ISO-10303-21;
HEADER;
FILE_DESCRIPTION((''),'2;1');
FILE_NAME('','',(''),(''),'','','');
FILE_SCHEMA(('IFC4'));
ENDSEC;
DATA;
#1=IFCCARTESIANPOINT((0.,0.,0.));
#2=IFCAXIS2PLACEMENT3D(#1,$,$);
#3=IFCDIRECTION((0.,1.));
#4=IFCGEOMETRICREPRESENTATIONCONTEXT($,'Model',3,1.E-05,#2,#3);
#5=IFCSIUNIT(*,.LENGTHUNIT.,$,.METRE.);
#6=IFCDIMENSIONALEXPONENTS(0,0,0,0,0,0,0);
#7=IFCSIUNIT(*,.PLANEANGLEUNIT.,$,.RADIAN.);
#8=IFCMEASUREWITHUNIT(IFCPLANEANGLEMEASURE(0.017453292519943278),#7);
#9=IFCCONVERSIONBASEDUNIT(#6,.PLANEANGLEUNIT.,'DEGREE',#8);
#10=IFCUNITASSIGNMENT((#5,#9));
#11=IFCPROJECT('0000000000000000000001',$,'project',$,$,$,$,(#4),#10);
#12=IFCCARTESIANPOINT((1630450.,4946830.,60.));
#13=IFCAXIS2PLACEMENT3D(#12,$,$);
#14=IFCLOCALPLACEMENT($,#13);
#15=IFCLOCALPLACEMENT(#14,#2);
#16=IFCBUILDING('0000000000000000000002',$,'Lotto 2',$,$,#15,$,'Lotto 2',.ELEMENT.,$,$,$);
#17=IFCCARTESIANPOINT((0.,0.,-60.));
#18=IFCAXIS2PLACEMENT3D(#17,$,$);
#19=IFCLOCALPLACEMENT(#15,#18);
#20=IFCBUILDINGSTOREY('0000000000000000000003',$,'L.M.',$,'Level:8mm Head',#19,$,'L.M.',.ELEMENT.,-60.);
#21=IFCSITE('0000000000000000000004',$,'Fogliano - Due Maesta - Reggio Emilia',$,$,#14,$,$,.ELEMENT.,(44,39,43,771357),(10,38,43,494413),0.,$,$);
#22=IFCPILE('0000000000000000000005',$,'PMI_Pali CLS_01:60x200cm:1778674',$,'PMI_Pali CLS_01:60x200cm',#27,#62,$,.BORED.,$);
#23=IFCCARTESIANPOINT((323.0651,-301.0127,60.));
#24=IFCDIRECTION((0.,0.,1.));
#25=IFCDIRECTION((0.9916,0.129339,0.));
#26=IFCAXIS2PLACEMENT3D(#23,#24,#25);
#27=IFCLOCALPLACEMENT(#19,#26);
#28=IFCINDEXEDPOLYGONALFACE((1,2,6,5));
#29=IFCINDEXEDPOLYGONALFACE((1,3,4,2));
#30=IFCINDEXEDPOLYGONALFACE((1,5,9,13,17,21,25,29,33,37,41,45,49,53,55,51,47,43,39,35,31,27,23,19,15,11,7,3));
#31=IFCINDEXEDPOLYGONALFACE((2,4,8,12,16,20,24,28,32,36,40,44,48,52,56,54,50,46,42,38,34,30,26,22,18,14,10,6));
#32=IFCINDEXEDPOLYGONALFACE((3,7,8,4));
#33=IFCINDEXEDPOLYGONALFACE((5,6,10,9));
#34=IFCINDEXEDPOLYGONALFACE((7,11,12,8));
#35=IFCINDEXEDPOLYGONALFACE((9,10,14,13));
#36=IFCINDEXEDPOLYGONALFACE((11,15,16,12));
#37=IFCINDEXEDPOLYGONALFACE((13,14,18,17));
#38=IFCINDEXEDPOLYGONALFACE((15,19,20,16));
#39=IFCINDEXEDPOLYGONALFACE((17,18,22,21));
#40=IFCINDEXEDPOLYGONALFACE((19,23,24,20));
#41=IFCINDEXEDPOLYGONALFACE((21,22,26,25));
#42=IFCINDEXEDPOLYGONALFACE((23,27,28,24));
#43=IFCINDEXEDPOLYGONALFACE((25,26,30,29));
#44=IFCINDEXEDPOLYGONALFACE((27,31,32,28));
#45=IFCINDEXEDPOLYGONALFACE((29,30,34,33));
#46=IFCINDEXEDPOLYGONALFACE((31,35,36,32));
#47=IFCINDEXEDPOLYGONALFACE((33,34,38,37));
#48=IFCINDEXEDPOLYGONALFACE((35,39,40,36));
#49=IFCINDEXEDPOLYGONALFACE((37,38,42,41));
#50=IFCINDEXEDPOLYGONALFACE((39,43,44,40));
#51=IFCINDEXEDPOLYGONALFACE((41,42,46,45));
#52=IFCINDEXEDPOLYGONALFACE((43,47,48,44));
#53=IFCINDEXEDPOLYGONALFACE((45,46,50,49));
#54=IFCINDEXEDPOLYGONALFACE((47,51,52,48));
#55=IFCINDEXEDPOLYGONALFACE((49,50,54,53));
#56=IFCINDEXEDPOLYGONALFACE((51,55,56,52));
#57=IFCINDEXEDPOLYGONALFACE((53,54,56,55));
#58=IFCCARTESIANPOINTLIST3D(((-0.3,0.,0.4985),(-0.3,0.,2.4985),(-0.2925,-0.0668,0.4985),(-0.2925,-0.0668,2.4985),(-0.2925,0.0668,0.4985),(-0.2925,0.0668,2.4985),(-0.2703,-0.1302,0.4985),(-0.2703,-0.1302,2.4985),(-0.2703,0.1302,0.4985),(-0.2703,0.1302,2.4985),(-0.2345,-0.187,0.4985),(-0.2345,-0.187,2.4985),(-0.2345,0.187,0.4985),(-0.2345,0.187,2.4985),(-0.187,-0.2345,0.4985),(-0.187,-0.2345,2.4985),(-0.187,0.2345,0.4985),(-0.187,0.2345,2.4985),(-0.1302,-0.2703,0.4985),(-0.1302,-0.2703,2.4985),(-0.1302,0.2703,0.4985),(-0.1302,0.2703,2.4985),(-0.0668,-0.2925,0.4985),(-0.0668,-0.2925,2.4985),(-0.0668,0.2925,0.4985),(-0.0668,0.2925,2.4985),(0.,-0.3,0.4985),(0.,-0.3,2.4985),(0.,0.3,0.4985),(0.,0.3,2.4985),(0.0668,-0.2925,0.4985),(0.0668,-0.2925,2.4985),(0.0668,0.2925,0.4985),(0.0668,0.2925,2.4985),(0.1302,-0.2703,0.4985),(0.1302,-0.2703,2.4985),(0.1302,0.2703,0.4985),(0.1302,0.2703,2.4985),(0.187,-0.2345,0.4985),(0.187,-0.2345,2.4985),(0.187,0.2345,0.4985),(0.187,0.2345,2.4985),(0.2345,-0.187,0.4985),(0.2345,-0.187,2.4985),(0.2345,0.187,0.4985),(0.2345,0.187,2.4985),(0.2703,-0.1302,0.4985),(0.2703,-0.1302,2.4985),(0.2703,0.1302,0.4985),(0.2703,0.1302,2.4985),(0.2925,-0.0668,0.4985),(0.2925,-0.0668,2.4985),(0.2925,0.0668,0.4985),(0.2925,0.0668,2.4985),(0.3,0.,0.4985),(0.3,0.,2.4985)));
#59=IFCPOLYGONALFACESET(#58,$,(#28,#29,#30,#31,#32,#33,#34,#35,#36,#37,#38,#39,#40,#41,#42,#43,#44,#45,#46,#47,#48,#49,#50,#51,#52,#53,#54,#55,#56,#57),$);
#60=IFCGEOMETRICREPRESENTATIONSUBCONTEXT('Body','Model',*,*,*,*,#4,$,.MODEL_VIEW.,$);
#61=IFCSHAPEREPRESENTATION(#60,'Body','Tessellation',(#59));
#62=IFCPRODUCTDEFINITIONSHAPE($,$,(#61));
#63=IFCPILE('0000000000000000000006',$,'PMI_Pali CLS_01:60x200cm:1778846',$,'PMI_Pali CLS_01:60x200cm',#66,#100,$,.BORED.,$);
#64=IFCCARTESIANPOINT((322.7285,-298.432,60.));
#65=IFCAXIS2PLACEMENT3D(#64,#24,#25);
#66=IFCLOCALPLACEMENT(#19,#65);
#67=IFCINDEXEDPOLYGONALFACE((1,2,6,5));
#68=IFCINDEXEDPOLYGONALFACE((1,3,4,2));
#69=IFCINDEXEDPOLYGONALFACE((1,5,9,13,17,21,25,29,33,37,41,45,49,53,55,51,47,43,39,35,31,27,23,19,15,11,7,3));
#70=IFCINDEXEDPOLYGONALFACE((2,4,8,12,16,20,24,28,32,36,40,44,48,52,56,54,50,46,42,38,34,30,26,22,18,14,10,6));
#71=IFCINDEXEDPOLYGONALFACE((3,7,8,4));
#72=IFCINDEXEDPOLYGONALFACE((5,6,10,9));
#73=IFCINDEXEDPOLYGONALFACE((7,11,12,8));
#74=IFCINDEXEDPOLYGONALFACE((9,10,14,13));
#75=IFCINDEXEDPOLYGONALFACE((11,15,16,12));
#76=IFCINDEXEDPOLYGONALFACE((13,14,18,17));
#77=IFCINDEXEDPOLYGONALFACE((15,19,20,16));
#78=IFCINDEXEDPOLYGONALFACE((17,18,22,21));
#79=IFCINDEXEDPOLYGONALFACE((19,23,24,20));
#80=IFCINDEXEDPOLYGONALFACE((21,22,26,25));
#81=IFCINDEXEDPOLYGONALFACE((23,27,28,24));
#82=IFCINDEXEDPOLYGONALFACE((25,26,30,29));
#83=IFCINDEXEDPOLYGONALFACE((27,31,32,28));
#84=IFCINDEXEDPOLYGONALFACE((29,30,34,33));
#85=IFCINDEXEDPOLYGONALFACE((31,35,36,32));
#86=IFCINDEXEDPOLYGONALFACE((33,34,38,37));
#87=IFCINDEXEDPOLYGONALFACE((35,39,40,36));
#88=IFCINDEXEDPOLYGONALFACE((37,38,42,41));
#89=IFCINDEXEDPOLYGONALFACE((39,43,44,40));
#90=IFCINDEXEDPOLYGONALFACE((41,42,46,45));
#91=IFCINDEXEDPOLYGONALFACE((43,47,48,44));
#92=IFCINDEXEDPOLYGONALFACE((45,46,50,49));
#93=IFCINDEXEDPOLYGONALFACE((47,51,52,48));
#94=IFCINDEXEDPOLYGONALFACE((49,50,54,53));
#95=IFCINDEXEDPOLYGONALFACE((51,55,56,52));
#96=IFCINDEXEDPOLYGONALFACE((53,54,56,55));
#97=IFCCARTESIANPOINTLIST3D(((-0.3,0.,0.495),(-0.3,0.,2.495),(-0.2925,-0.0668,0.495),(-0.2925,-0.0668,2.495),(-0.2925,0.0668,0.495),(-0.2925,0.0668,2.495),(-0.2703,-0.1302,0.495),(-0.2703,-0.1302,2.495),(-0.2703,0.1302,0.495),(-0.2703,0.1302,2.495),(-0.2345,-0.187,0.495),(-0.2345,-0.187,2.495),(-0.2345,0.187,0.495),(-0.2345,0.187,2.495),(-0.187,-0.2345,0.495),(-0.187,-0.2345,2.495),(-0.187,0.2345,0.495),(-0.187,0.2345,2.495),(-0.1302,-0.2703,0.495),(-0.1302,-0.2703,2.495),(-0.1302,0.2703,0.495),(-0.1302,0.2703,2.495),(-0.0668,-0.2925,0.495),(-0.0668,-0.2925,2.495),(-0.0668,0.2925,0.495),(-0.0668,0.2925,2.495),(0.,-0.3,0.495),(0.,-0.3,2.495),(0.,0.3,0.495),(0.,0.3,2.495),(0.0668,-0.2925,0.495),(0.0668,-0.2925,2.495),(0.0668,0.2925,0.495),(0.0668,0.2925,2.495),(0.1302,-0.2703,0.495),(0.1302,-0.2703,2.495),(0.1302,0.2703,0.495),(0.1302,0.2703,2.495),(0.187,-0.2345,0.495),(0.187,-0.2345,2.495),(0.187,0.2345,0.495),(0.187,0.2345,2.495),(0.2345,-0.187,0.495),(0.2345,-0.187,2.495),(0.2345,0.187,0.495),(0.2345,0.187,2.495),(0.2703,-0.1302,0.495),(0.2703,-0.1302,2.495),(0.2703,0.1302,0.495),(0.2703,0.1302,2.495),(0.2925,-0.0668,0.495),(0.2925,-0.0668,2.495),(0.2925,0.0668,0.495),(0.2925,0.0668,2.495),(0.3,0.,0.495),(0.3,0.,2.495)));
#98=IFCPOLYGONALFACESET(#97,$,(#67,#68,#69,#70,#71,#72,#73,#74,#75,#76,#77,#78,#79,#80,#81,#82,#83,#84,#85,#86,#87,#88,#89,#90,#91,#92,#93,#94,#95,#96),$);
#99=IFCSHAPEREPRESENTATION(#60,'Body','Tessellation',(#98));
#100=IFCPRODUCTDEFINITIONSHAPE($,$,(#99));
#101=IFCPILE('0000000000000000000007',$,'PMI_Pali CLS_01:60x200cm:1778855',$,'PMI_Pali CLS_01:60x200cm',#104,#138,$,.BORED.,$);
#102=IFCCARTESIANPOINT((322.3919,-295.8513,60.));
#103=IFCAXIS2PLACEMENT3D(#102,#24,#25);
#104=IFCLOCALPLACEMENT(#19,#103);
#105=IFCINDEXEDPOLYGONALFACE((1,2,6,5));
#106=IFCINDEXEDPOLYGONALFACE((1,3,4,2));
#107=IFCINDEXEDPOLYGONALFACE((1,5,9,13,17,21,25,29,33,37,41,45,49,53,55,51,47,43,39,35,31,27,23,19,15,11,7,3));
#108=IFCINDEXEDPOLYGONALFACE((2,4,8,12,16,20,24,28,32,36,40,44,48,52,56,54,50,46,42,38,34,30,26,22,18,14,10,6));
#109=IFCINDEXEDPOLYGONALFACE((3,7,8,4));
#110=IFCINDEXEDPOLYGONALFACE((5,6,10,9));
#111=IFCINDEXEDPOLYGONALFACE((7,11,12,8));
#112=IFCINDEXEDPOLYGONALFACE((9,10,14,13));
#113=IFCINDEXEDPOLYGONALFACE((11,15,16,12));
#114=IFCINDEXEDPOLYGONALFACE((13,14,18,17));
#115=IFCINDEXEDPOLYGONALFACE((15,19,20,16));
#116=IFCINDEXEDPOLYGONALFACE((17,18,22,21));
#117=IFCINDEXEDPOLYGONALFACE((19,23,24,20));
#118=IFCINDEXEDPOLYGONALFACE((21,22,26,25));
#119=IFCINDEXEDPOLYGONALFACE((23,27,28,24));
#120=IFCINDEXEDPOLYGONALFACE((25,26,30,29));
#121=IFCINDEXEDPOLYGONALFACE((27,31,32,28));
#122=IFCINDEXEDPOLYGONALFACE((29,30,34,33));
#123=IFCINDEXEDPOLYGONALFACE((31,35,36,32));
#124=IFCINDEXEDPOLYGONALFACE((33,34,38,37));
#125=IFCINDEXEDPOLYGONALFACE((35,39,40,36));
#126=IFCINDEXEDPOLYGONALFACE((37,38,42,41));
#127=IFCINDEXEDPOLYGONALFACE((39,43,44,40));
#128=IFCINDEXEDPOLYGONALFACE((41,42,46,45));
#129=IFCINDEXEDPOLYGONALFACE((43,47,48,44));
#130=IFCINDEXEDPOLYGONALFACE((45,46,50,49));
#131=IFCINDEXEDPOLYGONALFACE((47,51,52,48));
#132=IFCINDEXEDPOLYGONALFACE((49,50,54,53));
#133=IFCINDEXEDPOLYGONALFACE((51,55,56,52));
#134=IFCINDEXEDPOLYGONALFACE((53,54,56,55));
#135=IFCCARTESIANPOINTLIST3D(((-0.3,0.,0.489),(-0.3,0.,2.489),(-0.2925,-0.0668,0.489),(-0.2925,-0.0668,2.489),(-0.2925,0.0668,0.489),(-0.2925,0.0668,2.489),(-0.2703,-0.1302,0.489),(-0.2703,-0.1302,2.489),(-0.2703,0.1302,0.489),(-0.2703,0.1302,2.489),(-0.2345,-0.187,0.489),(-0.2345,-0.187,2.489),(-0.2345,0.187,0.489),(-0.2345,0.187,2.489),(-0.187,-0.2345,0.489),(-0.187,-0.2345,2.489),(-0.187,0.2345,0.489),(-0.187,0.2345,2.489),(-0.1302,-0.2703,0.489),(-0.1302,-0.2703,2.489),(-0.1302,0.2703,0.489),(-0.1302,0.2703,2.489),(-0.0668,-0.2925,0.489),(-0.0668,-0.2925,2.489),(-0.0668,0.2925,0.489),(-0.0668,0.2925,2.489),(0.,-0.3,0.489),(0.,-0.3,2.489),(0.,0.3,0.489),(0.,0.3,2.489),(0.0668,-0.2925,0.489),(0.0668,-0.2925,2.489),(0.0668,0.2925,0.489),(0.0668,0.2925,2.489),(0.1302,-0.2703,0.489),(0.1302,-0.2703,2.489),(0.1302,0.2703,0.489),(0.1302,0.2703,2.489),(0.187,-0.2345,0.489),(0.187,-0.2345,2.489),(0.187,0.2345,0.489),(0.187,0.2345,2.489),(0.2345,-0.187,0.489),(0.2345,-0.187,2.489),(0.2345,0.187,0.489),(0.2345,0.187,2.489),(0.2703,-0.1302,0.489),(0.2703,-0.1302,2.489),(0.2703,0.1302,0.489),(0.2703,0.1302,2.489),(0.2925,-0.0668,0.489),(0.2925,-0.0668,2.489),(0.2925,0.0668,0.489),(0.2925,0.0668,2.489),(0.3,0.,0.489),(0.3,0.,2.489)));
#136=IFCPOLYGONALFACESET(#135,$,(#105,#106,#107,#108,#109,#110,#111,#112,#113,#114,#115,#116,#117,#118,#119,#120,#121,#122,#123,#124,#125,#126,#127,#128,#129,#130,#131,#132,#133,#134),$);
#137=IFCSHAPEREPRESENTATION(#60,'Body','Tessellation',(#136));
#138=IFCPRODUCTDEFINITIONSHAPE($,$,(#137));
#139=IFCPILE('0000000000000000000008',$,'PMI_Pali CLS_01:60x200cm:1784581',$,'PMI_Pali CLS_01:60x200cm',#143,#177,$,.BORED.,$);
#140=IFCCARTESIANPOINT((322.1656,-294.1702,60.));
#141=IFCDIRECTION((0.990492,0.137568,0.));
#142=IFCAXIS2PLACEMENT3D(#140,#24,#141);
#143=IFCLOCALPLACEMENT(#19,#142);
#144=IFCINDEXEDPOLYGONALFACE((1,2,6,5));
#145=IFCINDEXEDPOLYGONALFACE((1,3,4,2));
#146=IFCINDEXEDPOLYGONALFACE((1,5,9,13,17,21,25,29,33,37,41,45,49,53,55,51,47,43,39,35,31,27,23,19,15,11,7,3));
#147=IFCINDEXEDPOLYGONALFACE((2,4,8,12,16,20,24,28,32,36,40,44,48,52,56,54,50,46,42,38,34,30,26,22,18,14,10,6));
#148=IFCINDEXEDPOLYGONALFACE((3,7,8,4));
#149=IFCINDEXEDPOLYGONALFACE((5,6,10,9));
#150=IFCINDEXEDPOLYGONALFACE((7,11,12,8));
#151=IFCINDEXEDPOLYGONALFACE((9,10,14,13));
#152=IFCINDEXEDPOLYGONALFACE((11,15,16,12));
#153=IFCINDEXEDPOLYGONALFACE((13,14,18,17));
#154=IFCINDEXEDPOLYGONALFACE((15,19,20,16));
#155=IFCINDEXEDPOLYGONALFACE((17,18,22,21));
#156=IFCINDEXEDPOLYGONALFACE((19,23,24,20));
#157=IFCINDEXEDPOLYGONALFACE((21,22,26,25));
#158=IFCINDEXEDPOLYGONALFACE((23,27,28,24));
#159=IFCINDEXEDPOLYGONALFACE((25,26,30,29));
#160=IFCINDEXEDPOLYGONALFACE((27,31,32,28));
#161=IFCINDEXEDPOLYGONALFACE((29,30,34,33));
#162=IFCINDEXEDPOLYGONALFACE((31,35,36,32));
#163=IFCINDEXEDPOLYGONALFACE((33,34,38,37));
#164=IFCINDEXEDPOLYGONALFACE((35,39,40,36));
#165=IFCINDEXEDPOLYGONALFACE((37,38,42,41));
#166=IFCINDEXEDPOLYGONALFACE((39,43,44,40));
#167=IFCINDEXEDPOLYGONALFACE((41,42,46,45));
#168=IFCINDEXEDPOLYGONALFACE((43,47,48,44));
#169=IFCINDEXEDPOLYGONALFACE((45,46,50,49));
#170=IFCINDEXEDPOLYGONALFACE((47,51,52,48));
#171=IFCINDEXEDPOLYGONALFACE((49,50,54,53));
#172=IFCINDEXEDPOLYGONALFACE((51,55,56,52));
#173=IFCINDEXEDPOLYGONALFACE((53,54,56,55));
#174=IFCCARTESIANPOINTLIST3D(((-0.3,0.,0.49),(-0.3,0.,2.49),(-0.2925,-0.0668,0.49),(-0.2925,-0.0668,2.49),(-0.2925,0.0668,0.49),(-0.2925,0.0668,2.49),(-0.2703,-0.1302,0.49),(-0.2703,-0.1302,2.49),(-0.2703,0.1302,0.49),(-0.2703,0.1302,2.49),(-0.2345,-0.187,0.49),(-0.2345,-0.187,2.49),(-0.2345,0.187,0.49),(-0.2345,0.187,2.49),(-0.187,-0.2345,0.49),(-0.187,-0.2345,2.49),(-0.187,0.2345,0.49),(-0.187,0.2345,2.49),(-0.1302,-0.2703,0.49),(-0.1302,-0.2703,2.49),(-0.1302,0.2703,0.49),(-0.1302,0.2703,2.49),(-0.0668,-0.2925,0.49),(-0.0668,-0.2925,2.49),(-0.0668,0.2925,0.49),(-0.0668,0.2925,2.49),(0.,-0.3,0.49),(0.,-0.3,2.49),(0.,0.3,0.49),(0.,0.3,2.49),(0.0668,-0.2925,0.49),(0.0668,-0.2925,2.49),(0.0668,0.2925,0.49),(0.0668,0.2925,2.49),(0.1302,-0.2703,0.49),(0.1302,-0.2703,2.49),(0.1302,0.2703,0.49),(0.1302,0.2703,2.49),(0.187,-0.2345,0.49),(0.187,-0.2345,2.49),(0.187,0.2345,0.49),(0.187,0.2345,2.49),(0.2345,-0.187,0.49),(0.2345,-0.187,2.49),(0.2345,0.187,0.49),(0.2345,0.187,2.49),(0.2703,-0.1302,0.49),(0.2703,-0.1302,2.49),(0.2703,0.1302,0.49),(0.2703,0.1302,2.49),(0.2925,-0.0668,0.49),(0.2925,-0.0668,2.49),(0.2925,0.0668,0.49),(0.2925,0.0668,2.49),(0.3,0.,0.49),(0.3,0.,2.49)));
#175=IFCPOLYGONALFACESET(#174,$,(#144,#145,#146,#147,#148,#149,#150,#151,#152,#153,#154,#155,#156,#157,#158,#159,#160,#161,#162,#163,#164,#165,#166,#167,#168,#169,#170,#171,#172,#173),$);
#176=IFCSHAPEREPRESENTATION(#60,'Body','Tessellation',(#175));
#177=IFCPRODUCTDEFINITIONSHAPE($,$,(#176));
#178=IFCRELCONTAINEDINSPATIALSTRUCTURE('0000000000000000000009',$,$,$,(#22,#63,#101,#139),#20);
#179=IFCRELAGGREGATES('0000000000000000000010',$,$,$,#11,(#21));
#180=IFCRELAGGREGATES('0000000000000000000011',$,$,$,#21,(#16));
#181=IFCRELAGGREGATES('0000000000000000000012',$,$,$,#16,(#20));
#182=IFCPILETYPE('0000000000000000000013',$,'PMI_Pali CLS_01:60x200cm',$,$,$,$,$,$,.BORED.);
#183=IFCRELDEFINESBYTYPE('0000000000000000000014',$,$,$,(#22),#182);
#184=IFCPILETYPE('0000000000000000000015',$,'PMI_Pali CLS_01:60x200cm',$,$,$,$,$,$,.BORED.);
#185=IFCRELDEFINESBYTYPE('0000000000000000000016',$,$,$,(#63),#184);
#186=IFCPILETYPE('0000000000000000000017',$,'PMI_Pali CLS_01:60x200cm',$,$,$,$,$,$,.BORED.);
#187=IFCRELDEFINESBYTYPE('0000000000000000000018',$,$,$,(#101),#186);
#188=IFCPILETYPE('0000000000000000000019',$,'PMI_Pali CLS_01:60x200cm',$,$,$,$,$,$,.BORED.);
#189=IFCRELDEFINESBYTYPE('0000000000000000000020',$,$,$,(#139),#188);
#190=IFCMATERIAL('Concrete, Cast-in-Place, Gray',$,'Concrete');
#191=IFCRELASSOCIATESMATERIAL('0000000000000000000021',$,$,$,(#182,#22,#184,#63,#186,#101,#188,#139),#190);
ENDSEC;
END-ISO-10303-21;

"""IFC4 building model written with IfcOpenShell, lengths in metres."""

from ifc_helpers import new_model, entity, si_unit, converted_unit, direction, frame, origin, place, context, subcontext, project, spatial, arc, indexed_curve, outline, extrude, source, transform, mapped, material, type_object, type_shapes, element, save


model = new_model("IFC4")

# Units and contexts
model_context = context("Model", 3, precision=1e-05, world=origin(), true_north=direction((0.0, 1.0)))
body_context = subcontext(model_context, "Body", "Model", "MODEL_VIEW")
ifc_project = project(units=[si_unit("LENGTHUNIT", "METRE"), converted_unit("PLANEANGLEUNIT", "DEGREE", entity("IfcPlaneAngleMeasure", 0.017453292519943278), si_unit("PLANEANGLEUNIT", "RADIAN"), dimensions=[0, 0, 0, 0, 0, 0, 0])], contexts=[model_context])

# Site, building, storey
site_placement = place(None, frame((1630450.0, 4946830.0, 60.0)))
site = spatial("IfcSite", under=ifc_project, at=site_placement, Name="Fogliano - Due Maesta - Reggio Emilia", CompositionType="ELEMENT", RefLatitude=(44, 39, 43, 771357), RefLongitude=(10, 38, 43, 494413), RefElevation=0.0)
building_placement = place(site_placement, origin())
building = spatial("IfcBuilding", under=site, at=building_placement, Name="Lotto 2", LongName="Lotto 2", CompositionType="ELEMENT")
storey_placement = place(building_placement, frame((0.0, 0.0, -60.0)))
storey = spatial("IfcBuildingStorey", under=building, at=storey_placement, Name="L.M.", ObjectType="Level:8mm Head", LongName="L.M.", CompositionType="ELEMENT", Elevation=-60.0)

# Piles
ifc_material_1 = material(Name="Concrete, Cast-in-Place, Gray", Category="Concrete")
pile_type_1 = type_object("IfcPileType", Name="PMI_Pali CLS_01:60x200cm", PredefinedType="BORED", material=ifc_material_1)
shared_shape_1 = source(origin(), body_context, "Body", "SweptSolid", [
    extrude(outline(indexed_curve([(-0.3, 0.0), (0.0, -0.3), (0.3, 0.0), (0.0, 0.3)], segments=[arc(1, 2, 3), arc(3, 4, 1)], self_intersect=False)), frame((0.0, 0.0, 0.4985)), (0.0, 0.0, 1.0), 2.0),
])
type_shapes(pile_type_1, [shared_shape_1])
pile_1_placement = place(storey_placement, frame((323.0651, -301.0127, 60.0), z_axis=(0.0, 0.0, 1.0), x_axis=(0.9916, 0.129339, 0.0)))
element("IfcPile", 1, at=pile_1_placement, inside=storey, type_object=pile_type_1, material=ifc_material_1, Name="PMI_Pali CLS_01:60x200cm:1778674", ObjectType="PMI_Pali CLS_01:60x200cm", PredefinedType="BORED", context=body_context, shape_type="MappedRepresentation", body=[
    mapped(shared_shape_1, transform((0.0, 0.0, 0.0), scale=1.0)),
])
pile_type_2 = type_object("IfcPileType", Name="PMI_Pali CLS_01:60x200cm", PredefinedType="BORED", material=ifc_material_1)
shared_shape_2 = source(origin(), body_context, "Body", "SweptSolid", [
    extrude(outline(indexed_curve([(-0.3, 0.0), (0.0, -0.3), (0.3, 0.0), (0.0, 0.3)], segments=[arc(1, 2, 3), arc(3, 4, 1)], self_intersect=False)), frame((0.0, 0.0, 0.495)), (0.0, 0.0, 1.0), 2.0),
])
type_shapes(pile_type_2, [shared_shape_2])
pile_2_placement = place(storey_placement, frame((322.7285, -298.432, 60.0), z_axis=(0.0, 0.0, 1.0), x_axis=(0.9916, 0.129339, 0.0)))
element("IfcPile", 2, at=pile_2_placement, inside=storey, type_object=pile_type_2, material=ifc_material_1, Name="PMI_Pali CLS_01:60x200cm:1778846", ObjectType="PMI_Pali CLS_01:60x200cm", PredefinedType="BORED", context=body_context, shape_type="MappedRepresentation", body=[
    mapped(shared_shape_2, transform((0.0, 0.0, 0.0), scale=1.0)),
])
pile_type_3 = type_object("IfcPileType", Name="PMI_Pali CLS_01:60x200cm", PredefinedType="BORED", material=ifc_material_1)
shared_shape_3 = source(origin(), body_context, "Body", "SweptSolid", [
    extrude(outline(indexed_curve([(-0.3, 0.0), (0.0, -0.3), (0.3, 0.0), (0.0, 0.3)], segments=[arc(1, 2, 3), arc(3, 4, 1)], self_intersect=False)), frame((0.0, 0.0, 0.489)), (0.0, 0.0, 1.0), 2.0),
])
type_shapes(pile_type_3, [shared_shape_3])
pile_3_placement = place(storey_placement, frame((322.3919, -295.8513, 60.0), z_axis=(0.0, 0.0, 1.0), x_axis=(0.9916, 0.129339, 0.0)))
element("IfcPile", 3, at=pile_3_placement, inside=storey, type_object=pile_type_3, material=ifc_material_1, Name="PMI_Pali CLS_01:60x200cm:1778855", ObjectType="PMI_Pali CLS_01:60x200cm", PredefinedType="BORED", context=body_context, shape_type="MappedRepresentation", body=[
    mapped(shared_shape_3, transform((0.0, 0.0, 0.0), scale=1.0)),
])
pile_type_4 = type_object("IfcPileType", Name="PMI_Pali CLS_01:60x200cm", PredefinedType="BORED", material=ifc_material_1)
shared_shape_4 = source(origin(), body_context, "Body", "SweptSolid", [
    extrude(outline(indexed_curve([(-0.3, 0.0), (0.0, -0.3), (0.3, 0.0), (0.0, 0.3)], segments=[arc(1, 2, 3), arc(3, 4, 1)], self_intersect=False)), frame((0.0, 0.0, 0.49)), (0.0, 0.0, 1.0), 2.0),
])
type_shapes(pile_type_4, [shared_shape_4])
pile_4_placement = place(storey_placement, frame((322.1656, -294.1702, 60.0), z_axis=(0.0, 0.0, 1.0), x_axis=(0.990492, 0.137568, 0.0)))
element("IfcPile", 4, at=pile_4_placement, inside=storey, type_object=pile_type_4, material=ifc_material_1, Name="PMI_Pali CLS_01:60x200cm:1784581", ObjectType="PMI_Pali CLS_01:60x200cm", PredefinedType="BORED", context=body_context, shape_type="MappedRepresentation", body=[
    mapped(shared_shape_4, transform((0.0, 0.0, 0.0), scale=1.0)),
])

save(model, "model.ifc")
